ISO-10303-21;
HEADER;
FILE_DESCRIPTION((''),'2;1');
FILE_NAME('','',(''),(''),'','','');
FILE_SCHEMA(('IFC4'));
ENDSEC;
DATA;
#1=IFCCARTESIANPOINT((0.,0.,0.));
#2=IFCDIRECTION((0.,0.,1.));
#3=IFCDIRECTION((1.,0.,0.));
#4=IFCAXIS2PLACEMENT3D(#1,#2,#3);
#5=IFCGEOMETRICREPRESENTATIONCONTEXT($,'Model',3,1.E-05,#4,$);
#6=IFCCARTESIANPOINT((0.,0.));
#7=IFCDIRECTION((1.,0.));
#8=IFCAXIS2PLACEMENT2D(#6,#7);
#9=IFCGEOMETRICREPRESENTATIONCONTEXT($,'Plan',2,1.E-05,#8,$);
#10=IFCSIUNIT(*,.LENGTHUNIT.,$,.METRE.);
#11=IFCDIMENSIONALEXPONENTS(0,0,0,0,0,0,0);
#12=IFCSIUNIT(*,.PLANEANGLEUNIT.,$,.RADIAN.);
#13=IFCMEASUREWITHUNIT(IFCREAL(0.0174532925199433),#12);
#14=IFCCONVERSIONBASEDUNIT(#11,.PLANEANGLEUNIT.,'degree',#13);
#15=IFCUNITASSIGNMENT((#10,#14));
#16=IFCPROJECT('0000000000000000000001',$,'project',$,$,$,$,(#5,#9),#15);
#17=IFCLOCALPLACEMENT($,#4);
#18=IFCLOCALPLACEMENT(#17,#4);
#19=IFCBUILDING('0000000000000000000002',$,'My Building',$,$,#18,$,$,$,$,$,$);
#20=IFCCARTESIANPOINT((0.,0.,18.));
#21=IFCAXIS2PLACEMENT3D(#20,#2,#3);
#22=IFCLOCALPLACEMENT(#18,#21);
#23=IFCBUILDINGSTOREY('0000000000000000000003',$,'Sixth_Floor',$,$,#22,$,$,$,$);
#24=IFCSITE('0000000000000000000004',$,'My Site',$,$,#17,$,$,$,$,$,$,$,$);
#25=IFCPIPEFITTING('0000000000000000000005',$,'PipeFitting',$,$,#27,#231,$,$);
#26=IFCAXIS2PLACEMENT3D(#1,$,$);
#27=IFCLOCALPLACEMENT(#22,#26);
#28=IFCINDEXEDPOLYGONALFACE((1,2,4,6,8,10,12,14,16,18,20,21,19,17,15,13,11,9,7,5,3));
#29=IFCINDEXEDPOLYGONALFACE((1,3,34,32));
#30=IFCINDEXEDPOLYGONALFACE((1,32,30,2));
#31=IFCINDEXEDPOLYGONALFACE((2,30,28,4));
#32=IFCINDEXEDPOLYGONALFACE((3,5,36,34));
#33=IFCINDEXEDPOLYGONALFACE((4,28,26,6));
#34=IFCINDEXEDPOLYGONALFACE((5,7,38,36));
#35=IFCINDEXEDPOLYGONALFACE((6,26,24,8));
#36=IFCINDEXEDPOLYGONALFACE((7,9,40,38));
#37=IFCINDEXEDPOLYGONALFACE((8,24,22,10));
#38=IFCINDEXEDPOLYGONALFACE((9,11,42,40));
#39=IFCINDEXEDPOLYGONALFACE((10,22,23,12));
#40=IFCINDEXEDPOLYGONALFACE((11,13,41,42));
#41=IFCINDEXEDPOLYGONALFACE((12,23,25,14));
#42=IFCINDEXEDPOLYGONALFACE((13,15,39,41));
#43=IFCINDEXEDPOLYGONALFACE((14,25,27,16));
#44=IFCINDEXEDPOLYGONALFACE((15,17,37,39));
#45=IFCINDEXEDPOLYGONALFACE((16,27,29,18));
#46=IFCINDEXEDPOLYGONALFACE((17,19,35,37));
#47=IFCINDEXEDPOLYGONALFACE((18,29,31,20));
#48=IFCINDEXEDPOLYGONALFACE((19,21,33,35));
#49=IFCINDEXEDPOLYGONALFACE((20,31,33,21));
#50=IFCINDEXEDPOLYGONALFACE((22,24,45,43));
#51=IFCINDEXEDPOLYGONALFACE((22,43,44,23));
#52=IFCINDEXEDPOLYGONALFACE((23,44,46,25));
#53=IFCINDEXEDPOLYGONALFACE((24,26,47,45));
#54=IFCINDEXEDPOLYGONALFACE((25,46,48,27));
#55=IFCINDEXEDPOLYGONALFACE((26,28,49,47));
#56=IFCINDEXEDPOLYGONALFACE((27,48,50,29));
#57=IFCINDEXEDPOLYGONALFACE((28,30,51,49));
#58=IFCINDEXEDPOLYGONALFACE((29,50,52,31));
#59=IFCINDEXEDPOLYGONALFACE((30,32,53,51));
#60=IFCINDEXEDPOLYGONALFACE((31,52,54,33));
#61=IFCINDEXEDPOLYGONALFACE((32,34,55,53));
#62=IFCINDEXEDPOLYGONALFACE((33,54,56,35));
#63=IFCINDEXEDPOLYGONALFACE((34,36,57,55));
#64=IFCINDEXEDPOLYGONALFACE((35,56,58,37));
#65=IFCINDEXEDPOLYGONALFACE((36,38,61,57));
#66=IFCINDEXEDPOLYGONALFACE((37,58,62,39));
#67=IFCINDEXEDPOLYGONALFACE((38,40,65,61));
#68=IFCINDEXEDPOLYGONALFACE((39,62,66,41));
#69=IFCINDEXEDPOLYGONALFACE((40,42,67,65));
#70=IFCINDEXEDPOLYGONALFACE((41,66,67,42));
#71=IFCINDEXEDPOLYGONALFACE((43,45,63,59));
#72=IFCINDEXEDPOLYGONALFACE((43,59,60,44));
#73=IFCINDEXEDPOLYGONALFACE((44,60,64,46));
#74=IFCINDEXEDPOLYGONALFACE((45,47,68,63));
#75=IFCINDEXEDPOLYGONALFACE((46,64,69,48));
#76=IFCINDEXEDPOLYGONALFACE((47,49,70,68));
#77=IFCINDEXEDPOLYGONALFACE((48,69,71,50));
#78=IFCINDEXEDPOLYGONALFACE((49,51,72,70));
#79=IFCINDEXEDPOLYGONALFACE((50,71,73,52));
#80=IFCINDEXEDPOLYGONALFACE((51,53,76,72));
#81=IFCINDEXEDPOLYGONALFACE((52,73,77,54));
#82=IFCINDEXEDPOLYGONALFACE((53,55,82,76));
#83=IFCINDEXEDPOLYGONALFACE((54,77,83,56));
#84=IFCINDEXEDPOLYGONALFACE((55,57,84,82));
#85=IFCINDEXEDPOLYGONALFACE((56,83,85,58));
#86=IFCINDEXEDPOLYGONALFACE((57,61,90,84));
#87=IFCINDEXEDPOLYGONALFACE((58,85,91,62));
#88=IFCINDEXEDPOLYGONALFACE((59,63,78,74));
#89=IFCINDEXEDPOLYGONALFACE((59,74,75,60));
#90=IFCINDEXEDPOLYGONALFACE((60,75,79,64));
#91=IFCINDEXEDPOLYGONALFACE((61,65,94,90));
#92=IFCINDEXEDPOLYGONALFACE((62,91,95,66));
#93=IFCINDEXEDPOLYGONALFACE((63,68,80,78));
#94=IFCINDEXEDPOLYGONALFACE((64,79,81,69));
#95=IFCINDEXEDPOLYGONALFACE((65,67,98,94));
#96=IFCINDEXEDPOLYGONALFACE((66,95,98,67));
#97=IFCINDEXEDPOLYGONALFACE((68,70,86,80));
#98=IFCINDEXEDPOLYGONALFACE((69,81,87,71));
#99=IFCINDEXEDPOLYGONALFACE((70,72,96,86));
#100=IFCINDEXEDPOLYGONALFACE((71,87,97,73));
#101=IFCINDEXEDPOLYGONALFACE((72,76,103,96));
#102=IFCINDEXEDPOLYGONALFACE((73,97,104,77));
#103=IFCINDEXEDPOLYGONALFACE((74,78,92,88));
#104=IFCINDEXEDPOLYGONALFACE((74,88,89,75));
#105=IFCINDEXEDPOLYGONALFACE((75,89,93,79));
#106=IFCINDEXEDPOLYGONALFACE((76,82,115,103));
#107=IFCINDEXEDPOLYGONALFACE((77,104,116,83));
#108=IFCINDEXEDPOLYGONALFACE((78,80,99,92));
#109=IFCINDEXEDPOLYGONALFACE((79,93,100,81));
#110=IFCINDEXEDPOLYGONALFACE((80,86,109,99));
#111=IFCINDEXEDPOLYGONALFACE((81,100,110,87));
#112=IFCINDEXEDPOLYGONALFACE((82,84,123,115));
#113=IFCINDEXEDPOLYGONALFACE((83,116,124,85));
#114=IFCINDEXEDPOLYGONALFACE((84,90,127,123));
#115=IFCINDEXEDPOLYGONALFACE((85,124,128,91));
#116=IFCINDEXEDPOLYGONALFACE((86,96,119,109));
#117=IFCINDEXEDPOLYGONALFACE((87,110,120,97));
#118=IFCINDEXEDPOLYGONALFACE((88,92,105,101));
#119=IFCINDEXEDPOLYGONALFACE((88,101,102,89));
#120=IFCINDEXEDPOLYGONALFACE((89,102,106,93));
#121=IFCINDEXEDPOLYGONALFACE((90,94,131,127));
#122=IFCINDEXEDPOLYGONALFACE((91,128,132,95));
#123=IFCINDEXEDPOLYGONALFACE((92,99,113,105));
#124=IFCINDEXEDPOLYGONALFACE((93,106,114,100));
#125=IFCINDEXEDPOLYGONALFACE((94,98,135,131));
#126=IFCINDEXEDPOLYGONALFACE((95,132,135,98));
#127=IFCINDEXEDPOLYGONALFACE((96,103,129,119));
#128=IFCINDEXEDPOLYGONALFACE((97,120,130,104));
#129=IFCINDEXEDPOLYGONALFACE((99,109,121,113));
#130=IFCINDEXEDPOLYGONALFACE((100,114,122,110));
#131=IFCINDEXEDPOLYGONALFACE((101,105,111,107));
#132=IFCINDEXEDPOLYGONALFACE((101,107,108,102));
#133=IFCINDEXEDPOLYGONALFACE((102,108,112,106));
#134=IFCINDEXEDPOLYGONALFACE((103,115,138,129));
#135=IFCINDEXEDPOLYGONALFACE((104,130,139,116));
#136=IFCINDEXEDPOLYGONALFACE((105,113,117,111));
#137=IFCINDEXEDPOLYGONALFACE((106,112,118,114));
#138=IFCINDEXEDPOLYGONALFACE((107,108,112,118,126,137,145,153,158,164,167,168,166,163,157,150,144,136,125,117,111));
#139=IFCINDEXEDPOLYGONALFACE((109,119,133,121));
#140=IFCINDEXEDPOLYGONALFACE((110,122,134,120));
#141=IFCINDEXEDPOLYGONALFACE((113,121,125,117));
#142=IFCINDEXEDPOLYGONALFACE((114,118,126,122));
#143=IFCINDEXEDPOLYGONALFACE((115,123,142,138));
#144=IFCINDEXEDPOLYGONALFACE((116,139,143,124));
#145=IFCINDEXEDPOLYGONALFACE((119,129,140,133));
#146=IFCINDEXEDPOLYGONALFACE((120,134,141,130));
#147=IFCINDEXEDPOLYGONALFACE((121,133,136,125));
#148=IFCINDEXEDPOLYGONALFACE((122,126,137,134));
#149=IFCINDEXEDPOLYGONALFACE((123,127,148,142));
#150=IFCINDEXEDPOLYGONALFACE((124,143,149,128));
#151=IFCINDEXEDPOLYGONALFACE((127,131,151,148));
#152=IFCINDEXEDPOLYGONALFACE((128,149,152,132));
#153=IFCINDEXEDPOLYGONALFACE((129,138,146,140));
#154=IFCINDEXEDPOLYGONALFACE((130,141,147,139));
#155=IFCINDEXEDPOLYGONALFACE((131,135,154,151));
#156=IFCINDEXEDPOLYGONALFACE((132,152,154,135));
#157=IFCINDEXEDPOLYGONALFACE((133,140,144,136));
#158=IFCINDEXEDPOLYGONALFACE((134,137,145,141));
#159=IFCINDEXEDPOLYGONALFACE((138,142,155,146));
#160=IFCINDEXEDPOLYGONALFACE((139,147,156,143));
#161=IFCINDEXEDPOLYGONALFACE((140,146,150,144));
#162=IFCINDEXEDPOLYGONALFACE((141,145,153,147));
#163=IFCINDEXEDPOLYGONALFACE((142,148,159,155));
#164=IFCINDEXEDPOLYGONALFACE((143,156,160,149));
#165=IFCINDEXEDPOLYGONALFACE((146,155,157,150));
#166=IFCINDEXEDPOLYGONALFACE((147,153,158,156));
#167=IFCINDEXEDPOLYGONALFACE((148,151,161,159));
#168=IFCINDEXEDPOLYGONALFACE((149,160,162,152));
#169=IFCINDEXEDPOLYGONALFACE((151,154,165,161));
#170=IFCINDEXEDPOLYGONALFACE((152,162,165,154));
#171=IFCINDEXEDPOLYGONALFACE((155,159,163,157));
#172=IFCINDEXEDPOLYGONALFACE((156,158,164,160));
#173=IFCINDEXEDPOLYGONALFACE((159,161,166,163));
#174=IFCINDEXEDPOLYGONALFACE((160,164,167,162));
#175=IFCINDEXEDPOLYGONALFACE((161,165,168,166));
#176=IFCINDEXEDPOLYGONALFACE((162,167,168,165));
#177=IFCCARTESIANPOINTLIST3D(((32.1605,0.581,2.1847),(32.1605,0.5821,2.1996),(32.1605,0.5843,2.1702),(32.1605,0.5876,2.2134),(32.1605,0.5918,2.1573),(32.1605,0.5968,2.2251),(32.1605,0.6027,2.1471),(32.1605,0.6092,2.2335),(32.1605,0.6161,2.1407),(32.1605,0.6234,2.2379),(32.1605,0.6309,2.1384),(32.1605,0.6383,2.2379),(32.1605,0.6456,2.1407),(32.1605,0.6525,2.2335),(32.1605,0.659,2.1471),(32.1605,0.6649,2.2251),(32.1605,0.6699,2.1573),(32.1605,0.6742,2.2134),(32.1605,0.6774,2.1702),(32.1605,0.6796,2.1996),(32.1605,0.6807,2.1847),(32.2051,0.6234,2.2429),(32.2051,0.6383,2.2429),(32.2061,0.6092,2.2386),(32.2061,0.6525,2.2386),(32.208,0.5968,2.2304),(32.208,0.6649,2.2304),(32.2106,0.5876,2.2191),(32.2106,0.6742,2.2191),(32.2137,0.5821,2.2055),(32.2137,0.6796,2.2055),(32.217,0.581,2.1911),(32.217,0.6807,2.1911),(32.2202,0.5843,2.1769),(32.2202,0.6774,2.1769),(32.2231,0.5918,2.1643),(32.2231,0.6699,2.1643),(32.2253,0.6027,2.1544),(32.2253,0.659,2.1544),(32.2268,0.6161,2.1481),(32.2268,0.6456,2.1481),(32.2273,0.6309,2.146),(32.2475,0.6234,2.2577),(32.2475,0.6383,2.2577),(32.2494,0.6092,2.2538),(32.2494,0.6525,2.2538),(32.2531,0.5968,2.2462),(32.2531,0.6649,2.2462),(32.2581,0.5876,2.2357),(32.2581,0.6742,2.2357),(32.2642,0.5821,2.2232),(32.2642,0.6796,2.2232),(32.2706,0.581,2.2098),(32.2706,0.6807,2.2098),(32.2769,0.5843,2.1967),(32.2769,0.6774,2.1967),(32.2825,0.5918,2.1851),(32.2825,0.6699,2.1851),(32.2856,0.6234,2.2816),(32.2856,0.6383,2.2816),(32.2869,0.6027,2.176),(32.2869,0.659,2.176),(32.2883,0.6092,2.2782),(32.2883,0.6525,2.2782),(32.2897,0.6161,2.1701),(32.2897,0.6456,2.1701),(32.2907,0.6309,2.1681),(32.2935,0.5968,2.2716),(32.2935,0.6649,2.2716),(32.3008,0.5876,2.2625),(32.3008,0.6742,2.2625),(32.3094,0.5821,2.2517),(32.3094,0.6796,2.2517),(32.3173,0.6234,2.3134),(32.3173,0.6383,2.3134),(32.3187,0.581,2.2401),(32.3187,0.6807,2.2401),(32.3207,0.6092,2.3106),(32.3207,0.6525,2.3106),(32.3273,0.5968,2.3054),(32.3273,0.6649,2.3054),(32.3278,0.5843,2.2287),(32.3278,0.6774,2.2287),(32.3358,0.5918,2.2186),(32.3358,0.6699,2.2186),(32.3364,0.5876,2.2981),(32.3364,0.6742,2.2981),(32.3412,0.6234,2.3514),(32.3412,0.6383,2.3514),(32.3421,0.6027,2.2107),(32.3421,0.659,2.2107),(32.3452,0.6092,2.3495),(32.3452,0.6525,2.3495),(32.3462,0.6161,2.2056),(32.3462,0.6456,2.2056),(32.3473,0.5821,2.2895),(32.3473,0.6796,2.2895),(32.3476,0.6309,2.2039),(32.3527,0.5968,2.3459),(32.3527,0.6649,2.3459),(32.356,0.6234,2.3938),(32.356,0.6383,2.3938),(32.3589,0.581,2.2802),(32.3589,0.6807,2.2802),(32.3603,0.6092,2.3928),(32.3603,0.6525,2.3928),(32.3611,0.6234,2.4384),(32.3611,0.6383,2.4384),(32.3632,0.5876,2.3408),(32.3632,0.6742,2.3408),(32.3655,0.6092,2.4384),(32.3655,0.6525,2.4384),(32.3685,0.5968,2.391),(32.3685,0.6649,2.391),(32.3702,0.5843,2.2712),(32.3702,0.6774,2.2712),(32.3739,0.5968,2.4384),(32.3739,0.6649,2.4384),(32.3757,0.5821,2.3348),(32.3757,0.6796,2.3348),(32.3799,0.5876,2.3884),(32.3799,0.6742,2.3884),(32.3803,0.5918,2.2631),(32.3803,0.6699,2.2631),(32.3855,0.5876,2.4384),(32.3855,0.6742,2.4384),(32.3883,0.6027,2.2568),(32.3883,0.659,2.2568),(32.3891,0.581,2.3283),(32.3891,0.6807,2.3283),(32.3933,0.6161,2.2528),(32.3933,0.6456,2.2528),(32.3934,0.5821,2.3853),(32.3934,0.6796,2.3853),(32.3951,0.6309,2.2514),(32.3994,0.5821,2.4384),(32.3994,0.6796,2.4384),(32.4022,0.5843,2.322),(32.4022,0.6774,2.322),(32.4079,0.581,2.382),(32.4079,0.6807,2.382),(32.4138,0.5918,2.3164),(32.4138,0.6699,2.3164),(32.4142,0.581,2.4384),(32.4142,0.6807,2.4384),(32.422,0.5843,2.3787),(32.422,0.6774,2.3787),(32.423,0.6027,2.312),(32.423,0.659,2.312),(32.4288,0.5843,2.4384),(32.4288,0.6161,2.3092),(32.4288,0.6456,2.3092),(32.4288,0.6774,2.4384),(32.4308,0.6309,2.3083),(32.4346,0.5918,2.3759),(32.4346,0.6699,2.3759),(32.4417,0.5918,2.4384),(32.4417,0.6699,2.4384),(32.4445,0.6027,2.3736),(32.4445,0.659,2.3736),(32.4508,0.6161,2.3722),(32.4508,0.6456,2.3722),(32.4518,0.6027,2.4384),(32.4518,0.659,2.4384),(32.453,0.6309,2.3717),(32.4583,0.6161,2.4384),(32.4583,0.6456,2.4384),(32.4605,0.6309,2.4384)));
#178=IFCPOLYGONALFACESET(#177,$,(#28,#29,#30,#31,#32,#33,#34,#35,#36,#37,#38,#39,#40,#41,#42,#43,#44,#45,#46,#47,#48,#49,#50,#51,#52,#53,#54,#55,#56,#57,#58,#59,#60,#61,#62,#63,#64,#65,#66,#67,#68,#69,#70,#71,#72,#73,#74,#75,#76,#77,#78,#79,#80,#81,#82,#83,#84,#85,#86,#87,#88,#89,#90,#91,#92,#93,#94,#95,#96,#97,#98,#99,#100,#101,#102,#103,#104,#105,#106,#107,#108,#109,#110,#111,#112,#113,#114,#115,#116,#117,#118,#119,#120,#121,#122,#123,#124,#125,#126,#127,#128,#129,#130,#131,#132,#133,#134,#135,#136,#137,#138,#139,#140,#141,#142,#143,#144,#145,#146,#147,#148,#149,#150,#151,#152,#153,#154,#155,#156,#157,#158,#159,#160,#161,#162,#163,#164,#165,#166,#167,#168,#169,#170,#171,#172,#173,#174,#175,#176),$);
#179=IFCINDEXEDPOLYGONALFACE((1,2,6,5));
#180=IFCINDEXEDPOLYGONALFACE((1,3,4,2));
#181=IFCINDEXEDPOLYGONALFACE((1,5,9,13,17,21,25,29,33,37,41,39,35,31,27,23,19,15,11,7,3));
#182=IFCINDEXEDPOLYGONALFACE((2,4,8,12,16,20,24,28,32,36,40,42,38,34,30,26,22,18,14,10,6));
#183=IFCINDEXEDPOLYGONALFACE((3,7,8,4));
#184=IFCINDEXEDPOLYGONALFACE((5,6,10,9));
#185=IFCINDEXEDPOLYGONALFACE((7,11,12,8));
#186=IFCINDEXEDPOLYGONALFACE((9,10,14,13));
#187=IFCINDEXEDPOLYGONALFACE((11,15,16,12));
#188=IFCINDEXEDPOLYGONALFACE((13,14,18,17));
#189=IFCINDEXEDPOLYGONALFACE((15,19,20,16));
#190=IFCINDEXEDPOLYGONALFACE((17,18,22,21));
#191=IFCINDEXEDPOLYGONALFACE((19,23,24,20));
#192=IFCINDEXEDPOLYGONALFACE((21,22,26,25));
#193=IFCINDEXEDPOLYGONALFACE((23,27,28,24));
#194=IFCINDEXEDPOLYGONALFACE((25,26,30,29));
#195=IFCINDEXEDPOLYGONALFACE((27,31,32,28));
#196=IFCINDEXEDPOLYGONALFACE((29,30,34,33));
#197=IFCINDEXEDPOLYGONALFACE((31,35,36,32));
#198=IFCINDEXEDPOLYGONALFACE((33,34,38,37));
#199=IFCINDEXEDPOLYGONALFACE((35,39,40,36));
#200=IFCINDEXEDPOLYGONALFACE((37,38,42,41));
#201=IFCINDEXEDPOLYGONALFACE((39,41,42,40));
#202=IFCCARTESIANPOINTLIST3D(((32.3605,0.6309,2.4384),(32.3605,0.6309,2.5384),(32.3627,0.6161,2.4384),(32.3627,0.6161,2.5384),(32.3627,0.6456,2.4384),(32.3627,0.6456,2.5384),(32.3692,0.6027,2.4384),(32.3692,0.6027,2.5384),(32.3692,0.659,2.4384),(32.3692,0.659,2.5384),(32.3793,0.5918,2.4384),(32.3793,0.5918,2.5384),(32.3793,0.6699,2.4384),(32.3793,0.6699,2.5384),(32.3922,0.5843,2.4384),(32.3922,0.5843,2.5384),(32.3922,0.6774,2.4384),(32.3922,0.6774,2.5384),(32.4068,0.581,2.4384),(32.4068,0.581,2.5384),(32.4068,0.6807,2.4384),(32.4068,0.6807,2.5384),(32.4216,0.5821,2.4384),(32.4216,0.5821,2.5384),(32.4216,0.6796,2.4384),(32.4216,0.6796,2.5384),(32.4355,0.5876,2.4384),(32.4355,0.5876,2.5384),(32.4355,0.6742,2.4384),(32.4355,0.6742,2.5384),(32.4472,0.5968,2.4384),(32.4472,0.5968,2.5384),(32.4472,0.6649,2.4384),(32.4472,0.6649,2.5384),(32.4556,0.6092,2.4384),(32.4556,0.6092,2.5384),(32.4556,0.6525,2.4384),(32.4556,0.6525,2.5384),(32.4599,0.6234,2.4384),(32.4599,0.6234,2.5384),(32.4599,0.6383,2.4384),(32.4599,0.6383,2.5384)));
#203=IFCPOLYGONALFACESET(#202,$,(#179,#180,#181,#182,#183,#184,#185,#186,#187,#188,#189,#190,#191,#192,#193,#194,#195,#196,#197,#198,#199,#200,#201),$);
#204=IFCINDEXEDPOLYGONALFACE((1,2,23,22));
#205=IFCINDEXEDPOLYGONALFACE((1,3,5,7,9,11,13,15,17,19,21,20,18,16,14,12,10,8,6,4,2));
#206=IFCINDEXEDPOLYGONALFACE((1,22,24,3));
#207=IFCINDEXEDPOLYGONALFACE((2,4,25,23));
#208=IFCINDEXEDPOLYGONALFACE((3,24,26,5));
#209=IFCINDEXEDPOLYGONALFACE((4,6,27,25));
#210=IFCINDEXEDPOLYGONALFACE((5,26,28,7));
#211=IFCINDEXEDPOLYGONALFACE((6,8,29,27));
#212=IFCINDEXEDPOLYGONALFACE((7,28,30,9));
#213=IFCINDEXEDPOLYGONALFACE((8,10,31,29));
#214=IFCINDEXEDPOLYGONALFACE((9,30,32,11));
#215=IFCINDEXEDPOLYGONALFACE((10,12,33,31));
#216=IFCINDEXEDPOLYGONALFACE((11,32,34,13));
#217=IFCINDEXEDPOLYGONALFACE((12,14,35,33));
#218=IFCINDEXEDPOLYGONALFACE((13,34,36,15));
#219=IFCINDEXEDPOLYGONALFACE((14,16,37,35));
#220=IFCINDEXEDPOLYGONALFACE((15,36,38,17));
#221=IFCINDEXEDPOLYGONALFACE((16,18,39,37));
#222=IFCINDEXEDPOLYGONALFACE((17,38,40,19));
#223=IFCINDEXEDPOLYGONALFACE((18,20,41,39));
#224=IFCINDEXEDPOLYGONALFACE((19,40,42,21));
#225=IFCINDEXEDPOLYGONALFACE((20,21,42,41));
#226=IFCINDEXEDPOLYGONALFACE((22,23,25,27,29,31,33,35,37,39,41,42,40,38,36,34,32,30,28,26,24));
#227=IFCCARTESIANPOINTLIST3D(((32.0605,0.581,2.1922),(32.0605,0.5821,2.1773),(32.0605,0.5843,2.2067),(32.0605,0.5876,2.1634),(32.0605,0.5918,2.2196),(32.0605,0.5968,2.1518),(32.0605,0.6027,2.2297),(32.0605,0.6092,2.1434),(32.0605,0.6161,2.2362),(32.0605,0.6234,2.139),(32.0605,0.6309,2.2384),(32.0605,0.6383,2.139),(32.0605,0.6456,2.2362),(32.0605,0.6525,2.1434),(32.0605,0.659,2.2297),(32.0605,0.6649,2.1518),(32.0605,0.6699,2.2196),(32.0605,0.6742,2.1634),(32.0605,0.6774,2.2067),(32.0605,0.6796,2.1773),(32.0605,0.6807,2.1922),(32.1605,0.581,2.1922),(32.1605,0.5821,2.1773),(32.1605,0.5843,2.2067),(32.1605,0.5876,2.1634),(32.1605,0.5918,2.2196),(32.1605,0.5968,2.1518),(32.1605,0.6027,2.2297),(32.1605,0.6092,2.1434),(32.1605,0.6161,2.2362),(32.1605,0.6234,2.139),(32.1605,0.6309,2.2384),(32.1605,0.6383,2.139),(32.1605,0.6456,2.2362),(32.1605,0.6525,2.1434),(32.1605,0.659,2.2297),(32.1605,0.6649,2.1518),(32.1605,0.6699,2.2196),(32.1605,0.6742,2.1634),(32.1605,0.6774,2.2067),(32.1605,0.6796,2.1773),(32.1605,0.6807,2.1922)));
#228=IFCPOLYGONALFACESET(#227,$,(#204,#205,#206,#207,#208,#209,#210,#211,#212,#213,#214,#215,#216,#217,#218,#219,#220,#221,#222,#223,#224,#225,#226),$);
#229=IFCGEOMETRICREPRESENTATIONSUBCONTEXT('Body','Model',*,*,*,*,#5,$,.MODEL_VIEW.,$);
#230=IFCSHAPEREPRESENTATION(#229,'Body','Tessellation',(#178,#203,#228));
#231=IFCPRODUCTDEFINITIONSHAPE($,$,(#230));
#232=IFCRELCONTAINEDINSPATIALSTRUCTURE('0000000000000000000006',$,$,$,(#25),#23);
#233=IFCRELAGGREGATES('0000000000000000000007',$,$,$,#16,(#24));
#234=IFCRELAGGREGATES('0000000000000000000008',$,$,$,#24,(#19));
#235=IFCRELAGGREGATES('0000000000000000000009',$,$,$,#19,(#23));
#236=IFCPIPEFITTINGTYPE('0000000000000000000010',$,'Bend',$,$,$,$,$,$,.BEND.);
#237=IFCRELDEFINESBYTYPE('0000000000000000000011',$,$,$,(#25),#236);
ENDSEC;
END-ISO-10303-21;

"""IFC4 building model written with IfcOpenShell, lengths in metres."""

from ifc_helpers import new_model, entity, si_unit, converted_unit, frame, origin_with_axes, origin_2d_with_axis, place, context, subcontext, project, spatial, circle, extrude, source, transform, mapped, type_object, type_shapes, element, save


model = new_model("IFC4")

# Units and contexts
model_context = context("Model", 3, precision=1e-05, world=origin_with_axes())
plan_context = context("Plan", 2, precision=1e-05, world=origin_2d_with_axis())
body_context = subcontext(model_context, "Body", "Model", "MODEL_VIEW")
ifc_project = project(units=[si_unit("LENGTHUNIT", "METRE"), converted_unit("PLANEANGLEUNIT", "degree", entity("IfcReal", 0.0174532925199433), si_unit("PLANEANGLEUNIT", "RADIAN"), dimensions=[0, 0, 0, 0, 0, 0, 0])], contexts=[model_context, plan_context])

# Site, building, storey
site_placement = place(None, origin_with_axes())
site = spatial("IfcSite", under=ifc_project, at=site_placement, Name="My Site")
building_placement = place(site_placement, origin_with_axes())
building = spatial("IfcBuilding", under=site, at=building_placement, Name="My Building")
storey_placement = place(building_placement, frame((0.0, 0.0, 18.0), z_axis=(0.0, 0.0, 1.0), x_axis=(1.0, 0.0, 0.0)))
storey = spatial("IfcBuildingStorey", under=building, at=storey_placement, Name="Sixth_Floor")

# Pipe fitting
pipe_fitting_type = type_object("IfcPipeFittingType", Name="Bend", PredefinedType="BEND")
shared_shape = source(origin_with_axes(), body_context, "Body", "SolidModel", [
    entity("IfcSweptDiskSolid", entity("IfcIndexedPolyCurve", entity("IfcCartesianPointList3D", [[0.0, 0.0, -0.1], [0.0732, 0.0, -0.2768], [0.25, 0.0, -0.35]]), [entity("IfcArcIndex", [1, 2, 3])]), 0.05),
    extrude(circle(Radius=0.05), origin_with_axes(), (0.0, 0.0, -1.0), 0.1),
    extrude(circle(Radius=0.05), frame((0.25, 0.0, -0.35), z_axis=(1.0, 0.0, 0.0), x_axis=(0.0, 0.0, 1.0)), (0.0, 0.0, 1.0), 0.1),
])
type_shapes(pipe_fitting_type, [shared_shape])
for number, where, z_axis, x_axis, name in (
    (1, (32.4105, 0.6309, 2.5384), (0.0, 0.0, 1.0), (-1.0, 0.0, 0.0), "PipeFitting"),
):
    element("IfcPipeFitting", number, at=place(storey_placement, frame(where, z_axis=z_axis, x_axis=x_axis)), inside=storey, type_object=pipe_fitting_type, Name=name, context=body_context, shape_type="MappedRepresentation", body=[
        mapped(shared_shape, transform((0.0, 0.0, 0.0), x_axis=(1.0, 0.0, 0.0), y_axis=(0.0, 1.0, 0.0), z_axis=(0.0, 0.0, 1.0), scale=1.0)),
    ])

save(model, "model.ifc")
